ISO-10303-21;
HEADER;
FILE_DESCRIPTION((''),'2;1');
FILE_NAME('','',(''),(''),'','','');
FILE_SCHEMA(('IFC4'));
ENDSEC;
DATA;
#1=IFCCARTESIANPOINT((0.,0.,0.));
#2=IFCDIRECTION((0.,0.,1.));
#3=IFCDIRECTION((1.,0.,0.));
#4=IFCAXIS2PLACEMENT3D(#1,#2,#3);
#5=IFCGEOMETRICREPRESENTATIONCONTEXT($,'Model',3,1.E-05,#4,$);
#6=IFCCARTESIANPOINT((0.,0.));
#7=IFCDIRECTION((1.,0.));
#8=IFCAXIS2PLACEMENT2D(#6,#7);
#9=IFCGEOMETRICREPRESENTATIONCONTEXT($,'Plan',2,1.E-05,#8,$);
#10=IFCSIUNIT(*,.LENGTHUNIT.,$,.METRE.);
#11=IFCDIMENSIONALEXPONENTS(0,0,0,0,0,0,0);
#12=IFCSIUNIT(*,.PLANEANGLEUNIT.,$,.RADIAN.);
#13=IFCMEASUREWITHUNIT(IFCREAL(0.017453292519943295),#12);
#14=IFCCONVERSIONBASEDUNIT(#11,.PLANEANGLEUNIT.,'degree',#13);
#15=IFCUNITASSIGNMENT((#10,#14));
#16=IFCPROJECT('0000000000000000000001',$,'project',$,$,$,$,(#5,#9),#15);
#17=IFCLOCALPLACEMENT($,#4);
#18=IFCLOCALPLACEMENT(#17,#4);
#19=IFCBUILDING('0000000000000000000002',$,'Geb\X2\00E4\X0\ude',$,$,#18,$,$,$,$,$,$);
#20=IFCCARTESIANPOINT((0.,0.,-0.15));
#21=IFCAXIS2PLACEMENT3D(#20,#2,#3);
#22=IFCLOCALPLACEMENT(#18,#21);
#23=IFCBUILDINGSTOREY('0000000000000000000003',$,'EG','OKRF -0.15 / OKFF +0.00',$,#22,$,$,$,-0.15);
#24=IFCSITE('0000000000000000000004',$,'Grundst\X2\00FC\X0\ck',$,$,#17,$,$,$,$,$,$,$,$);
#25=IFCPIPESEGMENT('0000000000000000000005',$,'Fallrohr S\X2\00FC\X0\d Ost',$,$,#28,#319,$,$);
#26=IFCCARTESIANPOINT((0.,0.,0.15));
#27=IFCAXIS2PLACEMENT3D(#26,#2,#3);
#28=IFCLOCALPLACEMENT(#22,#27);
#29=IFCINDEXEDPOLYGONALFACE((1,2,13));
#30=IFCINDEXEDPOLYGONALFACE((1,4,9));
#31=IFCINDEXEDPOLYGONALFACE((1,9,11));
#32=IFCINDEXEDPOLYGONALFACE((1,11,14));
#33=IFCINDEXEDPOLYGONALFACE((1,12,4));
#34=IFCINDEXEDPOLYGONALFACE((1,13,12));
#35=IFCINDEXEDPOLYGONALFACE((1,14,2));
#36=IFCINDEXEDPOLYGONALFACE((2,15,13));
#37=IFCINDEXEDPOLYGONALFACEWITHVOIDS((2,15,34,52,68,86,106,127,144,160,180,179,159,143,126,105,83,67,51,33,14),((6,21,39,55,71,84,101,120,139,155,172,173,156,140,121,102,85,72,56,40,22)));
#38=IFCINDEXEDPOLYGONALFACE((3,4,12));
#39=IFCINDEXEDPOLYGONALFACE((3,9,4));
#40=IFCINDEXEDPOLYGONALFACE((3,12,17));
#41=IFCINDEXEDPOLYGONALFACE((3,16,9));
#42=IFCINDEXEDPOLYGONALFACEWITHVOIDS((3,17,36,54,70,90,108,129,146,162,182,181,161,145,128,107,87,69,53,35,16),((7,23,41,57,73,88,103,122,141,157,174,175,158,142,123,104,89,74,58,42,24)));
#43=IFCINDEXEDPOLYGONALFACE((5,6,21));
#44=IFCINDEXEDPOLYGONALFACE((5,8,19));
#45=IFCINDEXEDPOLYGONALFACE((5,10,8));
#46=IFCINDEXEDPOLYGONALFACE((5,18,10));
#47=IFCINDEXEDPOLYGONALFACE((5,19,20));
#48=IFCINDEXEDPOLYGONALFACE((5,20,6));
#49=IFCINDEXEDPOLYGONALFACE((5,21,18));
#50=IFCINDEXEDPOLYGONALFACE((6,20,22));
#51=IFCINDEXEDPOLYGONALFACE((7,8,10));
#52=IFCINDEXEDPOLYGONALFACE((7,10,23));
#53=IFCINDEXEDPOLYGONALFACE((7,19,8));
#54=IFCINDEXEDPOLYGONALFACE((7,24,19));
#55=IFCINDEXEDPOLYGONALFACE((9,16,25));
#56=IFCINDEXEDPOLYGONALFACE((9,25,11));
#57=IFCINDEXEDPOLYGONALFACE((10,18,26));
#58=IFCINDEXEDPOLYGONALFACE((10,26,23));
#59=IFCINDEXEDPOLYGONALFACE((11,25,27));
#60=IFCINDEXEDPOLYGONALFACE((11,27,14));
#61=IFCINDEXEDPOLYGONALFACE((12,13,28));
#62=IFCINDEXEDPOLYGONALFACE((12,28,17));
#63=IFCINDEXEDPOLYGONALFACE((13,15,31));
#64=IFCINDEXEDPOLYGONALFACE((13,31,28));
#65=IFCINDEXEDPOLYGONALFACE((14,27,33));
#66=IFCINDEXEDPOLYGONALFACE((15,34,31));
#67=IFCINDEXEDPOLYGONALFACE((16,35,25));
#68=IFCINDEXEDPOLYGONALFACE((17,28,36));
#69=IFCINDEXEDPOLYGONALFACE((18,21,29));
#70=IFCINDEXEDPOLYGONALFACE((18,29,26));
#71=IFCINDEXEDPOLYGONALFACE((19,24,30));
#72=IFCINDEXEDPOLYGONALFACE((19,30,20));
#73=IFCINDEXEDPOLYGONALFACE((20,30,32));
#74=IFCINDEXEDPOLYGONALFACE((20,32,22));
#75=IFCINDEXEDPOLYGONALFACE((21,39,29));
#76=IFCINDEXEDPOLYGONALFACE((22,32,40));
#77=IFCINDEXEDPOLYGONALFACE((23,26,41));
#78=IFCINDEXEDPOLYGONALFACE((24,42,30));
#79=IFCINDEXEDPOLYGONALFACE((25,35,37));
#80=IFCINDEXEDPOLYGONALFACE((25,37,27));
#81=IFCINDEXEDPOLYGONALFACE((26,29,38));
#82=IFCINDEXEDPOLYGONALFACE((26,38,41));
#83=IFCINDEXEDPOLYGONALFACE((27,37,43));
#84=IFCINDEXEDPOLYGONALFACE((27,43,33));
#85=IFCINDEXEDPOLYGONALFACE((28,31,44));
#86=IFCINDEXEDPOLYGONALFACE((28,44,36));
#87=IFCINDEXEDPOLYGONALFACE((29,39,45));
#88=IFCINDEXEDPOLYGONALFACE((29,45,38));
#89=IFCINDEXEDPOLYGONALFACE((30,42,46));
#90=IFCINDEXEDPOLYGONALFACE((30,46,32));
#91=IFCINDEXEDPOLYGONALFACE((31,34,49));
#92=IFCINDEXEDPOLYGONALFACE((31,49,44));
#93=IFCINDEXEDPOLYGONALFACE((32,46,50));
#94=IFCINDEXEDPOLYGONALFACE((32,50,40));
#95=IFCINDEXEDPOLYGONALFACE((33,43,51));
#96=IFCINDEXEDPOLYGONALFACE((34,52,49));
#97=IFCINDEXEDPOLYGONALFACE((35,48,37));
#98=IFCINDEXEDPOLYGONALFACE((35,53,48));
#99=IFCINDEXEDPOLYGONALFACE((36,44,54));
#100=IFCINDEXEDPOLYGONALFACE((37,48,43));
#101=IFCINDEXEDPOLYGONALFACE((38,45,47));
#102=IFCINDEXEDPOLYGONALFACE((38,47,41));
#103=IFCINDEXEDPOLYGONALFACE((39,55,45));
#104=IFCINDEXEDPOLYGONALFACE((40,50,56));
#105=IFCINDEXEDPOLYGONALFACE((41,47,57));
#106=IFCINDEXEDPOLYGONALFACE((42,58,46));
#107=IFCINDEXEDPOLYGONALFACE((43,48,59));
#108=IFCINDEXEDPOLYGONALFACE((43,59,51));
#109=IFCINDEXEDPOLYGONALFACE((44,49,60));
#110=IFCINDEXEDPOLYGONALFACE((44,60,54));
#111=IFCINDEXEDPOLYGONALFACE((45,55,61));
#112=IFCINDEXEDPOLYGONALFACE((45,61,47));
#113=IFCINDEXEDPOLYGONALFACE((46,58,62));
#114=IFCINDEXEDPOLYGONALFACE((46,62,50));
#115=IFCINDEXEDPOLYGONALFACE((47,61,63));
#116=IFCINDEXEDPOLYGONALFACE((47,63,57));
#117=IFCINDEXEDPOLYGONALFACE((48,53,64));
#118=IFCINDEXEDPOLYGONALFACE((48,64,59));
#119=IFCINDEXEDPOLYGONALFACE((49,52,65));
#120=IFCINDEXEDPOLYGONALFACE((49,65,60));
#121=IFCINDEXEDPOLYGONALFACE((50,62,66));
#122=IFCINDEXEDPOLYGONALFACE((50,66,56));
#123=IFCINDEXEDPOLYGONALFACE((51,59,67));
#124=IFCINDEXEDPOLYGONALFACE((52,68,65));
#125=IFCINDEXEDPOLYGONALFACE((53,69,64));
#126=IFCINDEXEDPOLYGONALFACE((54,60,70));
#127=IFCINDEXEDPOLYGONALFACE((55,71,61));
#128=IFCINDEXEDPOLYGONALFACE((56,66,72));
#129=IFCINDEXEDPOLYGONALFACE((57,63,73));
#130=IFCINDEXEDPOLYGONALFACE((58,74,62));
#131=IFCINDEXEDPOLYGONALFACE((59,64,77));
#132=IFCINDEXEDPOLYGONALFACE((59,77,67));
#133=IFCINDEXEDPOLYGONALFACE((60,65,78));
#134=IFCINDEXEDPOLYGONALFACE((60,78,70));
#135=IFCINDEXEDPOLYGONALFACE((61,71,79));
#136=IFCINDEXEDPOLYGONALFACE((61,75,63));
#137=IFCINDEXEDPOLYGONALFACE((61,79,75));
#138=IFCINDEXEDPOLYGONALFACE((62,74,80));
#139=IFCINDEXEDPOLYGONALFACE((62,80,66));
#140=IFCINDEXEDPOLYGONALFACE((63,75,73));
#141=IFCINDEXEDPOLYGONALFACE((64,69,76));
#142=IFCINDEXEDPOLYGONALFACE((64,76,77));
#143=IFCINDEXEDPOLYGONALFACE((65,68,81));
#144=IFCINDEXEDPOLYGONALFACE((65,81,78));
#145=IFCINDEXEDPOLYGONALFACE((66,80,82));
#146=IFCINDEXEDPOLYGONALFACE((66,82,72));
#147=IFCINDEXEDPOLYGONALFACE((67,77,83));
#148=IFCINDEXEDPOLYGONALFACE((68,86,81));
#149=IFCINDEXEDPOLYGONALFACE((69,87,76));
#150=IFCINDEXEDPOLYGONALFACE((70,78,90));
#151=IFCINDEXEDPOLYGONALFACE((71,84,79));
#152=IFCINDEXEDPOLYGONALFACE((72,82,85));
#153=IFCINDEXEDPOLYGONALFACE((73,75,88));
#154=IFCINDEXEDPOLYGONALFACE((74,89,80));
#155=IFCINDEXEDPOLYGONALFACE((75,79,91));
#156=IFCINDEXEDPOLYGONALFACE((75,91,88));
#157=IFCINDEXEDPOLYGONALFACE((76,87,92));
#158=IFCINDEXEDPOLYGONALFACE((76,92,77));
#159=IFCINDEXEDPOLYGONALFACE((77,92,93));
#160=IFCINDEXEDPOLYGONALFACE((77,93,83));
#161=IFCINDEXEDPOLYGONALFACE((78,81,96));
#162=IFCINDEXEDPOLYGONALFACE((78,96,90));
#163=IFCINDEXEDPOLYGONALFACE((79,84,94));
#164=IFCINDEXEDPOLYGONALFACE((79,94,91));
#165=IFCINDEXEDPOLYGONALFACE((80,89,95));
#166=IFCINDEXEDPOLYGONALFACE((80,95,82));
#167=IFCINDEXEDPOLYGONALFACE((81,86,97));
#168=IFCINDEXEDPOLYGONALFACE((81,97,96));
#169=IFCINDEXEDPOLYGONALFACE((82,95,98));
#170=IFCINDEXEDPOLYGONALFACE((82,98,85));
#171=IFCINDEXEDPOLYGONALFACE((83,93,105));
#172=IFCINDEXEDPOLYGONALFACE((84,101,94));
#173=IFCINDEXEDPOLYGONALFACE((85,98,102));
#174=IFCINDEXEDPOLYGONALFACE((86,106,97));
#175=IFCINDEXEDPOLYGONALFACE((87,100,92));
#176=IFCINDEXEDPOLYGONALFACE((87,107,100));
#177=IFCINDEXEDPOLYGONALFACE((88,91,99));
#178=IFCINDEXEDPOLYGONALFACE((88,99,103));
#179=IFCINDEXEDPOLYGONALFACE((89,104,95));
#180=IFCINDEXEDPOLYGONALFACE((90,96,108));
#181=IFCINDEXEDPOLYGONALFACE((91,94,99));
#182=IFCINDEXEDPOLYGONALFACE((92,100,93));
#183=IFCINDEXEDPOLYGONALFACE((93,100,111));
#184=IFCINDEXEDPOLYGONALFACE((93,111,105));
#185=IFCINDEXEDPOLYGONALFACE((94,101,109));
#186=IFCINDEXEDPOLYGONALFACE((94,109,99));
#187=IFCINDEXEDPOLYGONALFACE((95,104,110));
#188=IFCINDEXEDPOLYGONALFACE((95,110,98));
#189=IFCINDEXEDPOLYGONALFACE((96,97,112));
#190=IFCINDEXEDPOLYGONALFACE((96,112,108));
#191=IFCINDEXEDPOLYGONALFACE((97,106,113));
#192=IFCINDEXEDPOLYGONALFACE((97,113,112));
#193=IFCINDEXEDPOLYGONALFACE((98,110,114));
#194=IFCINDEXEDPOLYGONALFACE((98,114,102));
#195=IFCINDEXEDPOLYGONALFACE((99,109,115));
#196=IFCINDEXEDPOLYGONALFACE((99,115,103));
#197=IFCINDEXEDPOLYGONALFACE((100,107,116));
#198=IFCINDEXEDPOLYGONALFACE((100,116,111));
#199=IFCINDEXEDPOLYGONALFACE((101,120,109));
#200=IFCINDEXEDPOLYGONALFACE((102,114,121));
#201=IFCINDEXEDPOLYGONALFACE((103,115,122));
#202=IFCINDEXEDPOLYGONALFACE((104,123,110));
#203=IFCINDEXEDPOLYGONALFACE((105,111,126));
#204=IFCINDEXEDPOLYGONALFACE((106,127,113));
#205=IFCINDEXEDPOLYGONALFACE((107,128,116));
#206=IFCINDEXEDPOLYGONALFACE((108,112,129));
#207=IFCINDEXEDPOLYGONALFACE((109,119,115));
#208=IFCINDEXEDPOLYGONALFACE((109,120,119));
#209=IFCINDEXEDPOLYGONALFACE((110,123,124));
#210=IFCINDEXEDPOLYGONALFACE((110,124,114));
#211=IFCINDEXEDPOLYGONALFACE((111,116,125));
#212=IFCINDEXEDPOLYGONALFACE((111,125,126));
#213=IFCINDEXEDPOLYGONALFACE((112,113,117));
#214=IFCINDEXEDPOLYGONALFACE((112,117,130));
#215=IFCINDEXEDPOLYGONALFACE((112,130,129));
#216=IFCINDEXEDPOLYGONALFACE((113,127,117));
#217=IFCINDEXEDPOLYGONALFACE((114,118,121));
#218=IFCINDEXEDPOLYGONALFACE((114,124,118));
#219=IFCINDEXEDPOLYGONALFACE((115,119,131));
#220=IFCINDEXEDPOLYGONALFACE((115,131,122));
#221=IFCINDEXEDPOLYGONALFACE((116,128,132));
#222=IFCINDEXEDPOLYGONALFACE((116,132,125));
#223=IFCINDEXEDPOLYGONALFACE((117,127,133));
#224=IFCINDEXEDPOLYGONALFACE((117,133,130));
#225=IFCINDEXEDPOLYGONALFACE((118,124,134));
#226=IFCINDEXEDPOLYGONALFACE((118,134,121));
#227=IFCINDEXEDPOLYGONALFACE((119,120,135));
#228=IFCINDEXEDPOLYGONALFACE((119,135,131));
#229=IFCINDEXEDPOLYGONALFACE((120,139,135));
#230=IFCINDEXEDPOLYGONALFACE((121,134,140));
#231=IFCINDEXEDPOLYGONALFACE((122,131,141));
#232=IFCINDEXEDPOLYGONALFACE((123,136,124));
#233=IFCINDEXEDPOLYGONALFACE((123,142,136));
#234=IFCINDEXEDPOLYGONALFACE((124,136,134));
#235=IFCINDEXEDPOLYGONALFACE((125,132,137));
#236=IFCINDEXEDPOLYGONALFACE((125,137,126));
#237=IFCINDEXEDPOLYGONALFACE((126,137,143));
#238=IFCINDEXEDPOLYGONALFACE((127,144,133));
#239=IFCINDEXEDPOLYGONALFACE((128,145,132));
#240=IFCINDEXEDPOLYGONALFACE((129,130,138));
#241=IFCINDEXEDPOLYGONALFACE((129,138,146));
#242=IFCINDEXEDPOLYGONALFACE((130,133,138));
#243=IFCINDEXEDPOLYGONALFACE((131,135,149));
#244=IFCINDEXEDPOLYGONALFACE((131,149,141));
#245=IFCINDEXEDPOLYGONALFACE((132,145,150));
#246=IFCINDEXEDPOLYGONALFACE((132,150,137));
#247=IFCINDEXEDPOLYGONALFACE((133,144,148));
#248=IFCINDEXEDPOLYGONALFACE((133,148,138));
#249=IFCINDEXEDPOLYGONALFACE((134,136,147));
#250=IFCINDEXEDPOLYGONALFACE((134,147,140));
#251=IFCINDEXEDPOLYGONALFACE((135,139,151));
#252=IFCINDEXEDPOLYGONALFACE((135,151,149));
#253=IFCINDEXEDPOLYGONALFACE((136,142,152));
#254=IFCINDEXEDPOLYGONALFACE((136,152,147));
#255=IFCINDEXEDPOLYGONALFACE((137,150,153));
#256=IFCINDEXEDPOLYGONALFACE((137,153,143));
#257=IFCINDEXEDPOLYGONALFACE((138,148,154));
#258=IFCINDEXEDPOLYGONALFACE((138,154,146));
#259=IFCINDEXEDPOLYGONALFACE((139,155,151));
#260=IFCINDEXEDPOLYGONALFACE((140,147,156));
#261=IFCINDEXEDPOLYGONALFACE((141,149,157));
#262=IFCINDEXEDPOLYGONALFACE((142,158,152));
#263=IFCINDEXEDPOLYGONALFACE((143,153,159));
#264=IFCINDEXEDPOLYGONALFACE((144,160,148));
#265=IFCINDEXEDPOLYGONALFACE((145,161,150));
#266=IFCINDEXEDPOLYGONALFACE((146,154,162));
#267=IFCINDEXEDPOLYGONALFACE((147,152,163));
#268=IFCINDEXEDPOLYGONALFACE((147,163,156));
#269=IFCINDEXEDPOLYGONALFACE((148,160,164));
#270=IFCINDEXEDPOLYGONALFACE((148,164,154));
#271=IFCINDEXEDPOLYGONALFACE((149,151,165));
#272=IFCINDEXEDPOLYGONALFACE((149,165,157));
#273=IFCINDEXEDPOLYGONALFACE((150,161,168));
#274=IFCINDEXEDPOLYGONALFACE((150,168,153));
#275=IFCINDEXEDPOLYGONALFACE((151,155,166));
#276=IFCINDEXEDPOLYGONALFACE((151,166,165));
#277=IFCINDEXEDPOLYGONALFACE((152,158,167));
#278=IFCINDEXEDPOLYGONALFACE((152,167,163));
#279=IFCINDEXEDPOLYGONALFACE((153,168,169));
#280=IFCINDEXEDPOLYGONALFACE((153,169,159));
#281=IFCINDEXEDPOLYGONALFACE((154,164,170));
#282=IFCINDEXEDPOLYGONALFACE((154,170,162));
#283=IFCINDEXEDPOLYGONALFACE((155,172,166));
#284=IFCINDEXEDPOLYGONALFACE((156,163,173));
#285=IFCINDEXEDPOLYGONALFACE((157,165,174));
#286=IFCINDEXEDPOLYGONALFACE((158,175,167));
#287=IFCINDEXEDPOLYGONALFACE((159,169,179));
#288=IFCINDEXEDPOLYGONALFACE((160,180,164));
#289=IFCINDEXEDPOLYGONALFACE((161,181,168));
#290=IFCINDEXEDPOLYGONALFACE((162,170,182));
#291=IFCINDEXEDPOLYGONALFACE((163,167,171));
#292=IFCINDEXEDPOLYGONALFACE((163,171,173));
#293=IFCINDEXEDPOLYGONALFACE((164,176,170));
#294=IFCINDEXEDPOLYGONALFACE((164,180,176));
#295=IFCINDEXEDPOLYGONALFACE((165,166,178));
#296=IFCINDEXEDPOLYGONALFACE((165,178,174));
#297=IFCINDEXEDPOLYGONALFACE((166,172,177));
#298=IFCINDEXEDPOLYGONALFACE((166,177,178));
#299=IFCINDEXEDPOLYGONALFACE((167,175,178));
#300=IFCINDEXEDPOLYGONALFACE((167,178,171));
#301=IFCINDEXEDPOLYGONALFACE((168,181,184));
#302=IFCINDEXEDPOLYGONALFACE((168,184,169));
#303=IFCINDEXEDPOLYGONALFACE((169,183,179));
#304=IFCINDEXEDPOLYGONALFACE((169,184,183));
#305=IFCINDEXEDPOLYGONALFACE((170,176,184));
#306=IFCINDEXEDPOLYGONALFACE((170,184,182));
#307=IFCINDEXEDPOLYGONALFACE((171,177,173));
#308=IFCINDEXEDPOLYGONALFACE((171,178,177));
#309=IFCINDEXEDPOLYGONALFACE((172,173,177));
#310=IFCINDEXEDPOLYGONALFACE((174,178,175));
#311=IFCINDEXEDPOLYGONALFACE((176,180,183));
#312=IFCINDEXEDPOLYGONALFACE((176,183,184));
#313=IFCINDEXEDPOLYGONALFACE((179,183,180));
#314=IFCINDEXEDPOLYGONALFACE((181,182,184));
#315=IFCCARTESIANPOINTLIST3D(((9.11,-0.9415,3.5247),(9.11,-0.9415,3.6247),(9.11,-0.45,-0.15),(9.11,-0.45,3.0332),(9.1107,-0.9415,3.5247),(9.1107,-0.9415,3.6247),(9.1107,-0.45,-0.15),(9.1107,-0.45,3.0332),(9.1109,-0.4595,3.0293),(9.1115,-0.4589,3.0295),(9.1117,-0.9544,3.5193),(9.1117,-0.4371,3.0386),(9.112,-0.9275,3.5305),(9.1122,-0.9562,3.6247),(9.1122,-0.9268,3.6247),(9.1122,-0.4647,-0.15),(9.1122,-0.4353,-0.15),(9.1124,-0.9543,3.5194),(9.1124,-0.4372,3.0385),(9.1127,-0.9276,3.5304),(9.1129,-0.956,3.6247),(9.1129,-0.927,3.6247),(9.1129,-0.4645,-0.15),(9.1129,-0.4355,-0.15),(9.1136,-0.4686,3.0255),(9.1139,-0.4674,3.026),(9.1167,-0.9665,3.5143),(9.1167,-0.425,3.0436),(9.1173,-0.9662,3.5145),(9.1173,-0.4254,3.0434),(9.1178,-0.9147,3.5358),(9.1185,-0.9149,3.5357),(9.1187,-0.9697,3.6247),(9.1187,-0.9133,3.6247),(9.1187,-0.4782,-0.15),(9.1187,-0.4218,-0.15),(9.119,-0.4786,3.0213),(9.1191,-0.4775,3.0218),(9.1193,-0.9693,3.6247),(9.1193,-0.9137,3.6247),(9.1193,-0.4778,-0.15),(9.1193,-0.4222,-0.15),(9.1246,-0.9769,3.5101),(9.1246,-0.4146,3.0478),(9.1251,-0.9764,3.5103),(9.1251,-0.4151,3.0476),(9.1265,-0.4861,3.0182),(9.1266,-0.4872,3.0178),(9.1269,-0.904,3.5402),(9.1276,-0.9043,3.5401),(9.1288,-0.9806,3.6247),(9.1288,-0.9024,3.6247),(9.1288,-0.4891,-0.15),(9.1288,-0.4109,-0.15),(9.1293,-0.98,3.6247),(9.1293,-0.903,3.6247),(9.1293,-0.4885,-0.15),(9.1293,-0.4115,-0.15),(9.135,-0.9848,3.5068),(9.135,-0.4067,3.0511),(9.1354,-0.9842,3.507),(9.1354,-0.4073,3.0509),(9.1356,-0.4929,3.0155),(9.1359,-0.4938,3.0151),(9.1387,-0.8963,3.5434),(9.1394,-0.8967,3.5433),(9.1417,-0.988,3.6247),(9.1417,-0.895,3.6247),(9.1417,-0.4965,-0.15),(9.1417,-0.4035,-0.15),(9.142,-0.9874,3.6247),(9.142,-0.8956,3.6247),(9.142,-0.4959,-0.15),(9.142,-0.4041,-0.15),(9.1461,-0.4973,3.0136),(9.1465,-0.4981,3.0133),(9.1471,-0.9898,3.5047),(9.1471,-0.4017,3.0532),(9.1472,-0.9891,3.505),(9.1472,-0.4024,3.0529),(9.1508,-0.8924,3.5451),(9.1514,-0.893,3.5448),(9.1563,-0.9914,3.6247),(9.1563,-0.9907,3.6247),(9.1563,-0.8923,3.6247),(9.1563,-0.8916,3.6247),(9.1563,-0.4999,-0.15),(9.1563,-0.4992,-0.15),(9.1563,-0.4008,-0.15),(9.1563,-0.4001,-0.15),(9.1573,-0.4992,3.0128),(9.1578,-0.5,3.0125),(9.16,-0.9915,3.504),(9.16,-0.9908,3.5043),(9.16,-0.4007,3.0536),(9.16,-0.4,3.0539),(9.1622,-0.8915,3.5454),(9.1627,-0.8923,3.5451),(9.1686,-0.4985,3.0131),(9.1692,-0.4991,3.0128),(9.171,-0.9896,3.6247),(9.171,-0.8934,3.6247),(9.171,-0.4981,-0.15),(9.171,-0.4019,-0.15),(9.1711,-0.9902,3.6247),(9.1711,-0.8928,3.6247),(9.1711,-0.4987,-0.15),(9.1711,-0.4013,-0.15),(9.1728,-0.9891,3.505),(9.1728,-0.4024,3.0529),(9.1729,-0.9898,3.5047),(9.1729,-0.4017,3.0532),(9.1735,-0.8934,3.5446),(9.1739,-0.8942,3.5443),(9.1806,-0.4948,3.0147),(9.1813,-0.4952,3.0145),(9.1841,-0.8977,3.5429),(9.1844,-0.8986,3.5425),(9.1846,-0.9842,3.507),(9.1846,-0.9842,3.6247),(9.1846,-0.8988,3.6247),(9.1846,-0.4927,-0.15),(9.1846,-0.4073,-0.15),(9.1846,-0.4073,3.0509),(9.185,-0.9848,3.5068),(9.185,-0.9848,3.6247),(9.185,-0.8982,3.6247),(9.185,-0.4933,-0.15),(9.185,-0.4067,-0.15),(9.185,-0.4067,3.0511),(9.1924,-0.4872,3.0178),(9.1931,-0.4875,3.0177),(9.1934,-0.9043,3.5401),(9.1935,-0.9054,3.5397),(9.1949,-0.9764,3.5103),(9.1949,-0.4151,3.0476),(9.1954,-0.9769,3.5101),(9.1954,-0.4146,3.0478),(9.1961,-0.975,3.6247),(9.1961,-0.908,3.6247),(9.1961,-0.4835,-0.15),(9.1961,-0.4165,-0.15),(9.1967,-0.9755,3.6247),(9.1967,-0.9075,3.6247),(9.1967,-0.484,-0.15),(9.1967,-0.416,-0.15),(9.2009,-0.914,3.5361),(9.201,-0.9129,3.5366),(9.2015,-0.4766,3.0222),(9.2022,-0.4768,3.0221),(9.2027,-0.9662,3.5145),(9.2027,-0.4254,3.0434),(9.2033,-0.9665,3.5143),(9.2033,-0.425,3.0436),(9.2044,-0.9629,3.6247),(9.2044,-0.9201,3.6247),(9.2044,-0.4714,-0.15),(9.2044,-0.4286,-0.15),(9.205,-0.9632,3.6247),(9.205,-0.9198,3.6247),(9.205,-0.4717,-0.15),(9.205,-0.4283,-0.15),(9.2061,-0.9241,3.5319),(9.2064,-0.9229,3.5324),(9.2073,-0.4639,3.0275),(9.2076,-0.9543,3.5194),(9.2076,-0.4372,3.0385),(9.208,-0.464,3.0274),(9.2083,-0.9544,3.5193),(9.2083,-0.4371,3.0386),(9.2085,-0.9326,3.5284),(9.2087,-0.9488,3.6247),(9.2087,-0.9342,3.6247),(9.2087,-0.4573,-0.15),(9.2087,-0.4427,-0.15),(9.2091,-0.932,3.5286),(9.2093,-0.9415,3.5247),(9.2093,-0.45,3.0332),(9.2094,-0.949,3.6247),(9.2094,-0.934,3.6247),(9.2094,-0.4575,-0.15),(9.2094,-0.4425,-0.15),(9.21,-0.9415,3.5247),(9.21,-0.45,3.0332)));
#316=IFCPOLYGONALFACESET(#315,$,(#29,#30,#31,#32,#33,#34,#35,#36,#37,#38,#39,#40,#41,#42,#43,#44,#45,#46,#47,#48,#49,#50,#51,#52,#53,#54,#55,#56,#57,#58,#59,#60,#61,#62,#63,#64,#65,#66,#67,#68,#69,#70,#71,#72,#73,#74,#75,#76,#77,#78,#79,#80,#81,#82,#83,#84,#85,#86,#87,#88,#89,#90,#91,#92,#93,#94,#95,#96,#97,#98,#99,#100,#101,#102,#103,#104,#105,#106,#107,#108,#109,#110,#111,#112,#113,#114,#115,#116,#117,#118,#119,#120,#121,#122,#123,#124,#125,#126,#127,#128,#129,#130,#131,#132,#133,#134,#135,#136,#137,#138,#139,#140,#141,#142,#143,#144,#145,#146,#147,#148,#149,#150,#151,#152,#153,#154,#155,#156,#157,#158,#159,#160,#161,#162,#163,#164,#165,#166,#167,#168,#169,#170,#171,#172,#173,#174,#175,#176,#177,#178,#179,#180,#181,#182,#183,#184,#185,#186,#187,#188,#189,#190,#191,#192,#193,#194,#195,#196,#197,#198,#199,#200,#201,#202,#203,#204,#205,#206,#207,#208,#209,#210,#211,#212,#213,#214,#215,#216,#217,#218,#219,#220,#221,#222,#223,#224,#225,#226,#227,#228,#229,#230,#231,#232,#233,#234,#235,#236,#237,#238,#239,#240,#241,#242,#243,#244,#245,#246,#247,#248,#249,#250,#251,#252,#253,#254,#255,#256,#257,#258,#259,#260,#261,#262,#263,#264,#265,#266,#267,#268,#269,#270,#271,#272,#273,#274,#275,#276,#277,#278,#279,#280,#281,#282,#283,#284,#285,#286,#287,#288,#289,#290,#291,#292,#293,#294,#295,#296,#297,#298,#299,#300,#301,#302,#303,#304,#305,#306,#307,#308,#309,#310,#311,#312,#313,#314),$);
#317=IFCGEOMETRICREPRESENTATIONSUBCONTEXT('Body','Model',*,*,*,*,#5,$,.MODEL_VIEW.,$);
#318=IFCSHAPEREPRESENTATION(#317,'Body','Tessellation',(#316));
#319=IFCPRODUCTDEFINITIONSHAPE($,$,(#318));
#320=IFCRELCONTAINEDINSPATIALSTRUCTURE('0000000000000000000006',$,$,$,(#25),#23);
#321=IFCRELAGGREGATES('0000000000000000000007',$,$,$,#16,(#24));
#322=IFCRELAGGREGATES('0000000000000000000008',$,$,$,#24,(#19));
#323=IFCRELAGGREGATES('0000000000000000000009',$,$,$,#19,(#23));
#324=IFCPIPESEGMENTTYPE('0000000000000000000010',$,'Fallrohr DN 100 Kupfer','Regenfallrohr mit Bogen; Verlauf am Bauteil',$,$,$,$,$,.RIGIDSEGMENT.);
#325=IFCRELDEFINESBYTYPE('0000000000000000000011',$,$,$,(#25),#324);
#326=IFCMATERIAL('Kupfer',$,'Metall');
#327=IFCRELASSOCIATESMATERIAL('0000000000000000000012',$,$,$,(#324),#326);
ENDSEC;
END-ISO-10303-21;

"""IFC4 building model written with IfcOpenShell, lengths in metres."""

from ifc_helpers import new_model, entity, si_unit, converted_unit, frame, origin_with_axes, origin_2d_with_axis, place, context, subcontext, project, spatial, material, type_object, element, save


model = new_model("IFC4")

# Units and contexts
model_context = context("Model", 3, precision=1e-05, world=origin_with_axes())
plan_context = context("Plan", 2, precision=1e-05, world=origin_2d_with_axis())
body_context = subcontext(model_context, "Body", "Model", "MODEL_VIEW")
ifc_project = project(units=[si_unit("LENGTHUNIT", "METRE"), converted_unit("PLANEANGLEUNIT", "degree", entity("IfcReal", 0.017453292519943295), si_unit("PLANEANGLEUNIT", "RADIAN"), dimensions=[0, 0, 0, 0, 0, 0, 0])], contexts=[model_context, plan_context])

# Site, building, storey
site_placement = place(None, origin_with_axes())
site = spatial("IfcSite", under=ifc_project, at=site_placement, Name="Grundstück")
building_placement = place(site_placement, origin_with_axes())
building = spatial("IfcBuilding", under=site, at=building_placement, Name="Gebäude")
storey_placement = place(building_placement, frame((0.0, 0.0, -0.15), z_axis=(0.0, 0.0, 1.0), x_axis=(1.0, 0.0, 0.0)))
storey = spatial("IfcBuildingStorey", under=building, at=storey_placement, Name="EG", Description="OKRF -0.15 / OKFF +0.00", Elevation=-0.15)

# Pipe segment
ifc_material_1 = material(Name="Kupfer", Category="Metall")
pipe_segment_type = type_object("IfcPipeSegmentType", Name="Fallrohr DN 100 Kupfer", Description="Regenfallrohr mit Bogen; Verlauf am Bauteil", PredefinedType="RIGIDSEGMENT", material=ifc_material_1)
pipe_segment_1_placement = place(storey_placement, frame((0.0, 0.0, 0.15), z_axis=(0.0, 0.0, 1.0), x_axis=(1.0, 0.0, 0.0)))
element("IfcPipeSegment", 1, at=pipe_segment_1_placement, inside=storey, type_object=pipe_segment_type, Name="Fallrohr Süd Ost", context=body_context, shape_type="AdvancedSweptSolid", body=[
    entity("IfcSweptDiskSolid", entity("IfcPolyline", [entity("IfcCartesianPoint", [9.16, -0.9415, 3.6247]), entity("IfcCartesianPoint", [9.16, -0.9415, 3.5247]), entity("IfcCartesianPoint", [9.16, -0.45, 3.0332]), entity("IfcCartesianPoint", [9.16, -0.45, -0.15])]), 0.05, 0.0493),
])

save(model, "model.ifc")
